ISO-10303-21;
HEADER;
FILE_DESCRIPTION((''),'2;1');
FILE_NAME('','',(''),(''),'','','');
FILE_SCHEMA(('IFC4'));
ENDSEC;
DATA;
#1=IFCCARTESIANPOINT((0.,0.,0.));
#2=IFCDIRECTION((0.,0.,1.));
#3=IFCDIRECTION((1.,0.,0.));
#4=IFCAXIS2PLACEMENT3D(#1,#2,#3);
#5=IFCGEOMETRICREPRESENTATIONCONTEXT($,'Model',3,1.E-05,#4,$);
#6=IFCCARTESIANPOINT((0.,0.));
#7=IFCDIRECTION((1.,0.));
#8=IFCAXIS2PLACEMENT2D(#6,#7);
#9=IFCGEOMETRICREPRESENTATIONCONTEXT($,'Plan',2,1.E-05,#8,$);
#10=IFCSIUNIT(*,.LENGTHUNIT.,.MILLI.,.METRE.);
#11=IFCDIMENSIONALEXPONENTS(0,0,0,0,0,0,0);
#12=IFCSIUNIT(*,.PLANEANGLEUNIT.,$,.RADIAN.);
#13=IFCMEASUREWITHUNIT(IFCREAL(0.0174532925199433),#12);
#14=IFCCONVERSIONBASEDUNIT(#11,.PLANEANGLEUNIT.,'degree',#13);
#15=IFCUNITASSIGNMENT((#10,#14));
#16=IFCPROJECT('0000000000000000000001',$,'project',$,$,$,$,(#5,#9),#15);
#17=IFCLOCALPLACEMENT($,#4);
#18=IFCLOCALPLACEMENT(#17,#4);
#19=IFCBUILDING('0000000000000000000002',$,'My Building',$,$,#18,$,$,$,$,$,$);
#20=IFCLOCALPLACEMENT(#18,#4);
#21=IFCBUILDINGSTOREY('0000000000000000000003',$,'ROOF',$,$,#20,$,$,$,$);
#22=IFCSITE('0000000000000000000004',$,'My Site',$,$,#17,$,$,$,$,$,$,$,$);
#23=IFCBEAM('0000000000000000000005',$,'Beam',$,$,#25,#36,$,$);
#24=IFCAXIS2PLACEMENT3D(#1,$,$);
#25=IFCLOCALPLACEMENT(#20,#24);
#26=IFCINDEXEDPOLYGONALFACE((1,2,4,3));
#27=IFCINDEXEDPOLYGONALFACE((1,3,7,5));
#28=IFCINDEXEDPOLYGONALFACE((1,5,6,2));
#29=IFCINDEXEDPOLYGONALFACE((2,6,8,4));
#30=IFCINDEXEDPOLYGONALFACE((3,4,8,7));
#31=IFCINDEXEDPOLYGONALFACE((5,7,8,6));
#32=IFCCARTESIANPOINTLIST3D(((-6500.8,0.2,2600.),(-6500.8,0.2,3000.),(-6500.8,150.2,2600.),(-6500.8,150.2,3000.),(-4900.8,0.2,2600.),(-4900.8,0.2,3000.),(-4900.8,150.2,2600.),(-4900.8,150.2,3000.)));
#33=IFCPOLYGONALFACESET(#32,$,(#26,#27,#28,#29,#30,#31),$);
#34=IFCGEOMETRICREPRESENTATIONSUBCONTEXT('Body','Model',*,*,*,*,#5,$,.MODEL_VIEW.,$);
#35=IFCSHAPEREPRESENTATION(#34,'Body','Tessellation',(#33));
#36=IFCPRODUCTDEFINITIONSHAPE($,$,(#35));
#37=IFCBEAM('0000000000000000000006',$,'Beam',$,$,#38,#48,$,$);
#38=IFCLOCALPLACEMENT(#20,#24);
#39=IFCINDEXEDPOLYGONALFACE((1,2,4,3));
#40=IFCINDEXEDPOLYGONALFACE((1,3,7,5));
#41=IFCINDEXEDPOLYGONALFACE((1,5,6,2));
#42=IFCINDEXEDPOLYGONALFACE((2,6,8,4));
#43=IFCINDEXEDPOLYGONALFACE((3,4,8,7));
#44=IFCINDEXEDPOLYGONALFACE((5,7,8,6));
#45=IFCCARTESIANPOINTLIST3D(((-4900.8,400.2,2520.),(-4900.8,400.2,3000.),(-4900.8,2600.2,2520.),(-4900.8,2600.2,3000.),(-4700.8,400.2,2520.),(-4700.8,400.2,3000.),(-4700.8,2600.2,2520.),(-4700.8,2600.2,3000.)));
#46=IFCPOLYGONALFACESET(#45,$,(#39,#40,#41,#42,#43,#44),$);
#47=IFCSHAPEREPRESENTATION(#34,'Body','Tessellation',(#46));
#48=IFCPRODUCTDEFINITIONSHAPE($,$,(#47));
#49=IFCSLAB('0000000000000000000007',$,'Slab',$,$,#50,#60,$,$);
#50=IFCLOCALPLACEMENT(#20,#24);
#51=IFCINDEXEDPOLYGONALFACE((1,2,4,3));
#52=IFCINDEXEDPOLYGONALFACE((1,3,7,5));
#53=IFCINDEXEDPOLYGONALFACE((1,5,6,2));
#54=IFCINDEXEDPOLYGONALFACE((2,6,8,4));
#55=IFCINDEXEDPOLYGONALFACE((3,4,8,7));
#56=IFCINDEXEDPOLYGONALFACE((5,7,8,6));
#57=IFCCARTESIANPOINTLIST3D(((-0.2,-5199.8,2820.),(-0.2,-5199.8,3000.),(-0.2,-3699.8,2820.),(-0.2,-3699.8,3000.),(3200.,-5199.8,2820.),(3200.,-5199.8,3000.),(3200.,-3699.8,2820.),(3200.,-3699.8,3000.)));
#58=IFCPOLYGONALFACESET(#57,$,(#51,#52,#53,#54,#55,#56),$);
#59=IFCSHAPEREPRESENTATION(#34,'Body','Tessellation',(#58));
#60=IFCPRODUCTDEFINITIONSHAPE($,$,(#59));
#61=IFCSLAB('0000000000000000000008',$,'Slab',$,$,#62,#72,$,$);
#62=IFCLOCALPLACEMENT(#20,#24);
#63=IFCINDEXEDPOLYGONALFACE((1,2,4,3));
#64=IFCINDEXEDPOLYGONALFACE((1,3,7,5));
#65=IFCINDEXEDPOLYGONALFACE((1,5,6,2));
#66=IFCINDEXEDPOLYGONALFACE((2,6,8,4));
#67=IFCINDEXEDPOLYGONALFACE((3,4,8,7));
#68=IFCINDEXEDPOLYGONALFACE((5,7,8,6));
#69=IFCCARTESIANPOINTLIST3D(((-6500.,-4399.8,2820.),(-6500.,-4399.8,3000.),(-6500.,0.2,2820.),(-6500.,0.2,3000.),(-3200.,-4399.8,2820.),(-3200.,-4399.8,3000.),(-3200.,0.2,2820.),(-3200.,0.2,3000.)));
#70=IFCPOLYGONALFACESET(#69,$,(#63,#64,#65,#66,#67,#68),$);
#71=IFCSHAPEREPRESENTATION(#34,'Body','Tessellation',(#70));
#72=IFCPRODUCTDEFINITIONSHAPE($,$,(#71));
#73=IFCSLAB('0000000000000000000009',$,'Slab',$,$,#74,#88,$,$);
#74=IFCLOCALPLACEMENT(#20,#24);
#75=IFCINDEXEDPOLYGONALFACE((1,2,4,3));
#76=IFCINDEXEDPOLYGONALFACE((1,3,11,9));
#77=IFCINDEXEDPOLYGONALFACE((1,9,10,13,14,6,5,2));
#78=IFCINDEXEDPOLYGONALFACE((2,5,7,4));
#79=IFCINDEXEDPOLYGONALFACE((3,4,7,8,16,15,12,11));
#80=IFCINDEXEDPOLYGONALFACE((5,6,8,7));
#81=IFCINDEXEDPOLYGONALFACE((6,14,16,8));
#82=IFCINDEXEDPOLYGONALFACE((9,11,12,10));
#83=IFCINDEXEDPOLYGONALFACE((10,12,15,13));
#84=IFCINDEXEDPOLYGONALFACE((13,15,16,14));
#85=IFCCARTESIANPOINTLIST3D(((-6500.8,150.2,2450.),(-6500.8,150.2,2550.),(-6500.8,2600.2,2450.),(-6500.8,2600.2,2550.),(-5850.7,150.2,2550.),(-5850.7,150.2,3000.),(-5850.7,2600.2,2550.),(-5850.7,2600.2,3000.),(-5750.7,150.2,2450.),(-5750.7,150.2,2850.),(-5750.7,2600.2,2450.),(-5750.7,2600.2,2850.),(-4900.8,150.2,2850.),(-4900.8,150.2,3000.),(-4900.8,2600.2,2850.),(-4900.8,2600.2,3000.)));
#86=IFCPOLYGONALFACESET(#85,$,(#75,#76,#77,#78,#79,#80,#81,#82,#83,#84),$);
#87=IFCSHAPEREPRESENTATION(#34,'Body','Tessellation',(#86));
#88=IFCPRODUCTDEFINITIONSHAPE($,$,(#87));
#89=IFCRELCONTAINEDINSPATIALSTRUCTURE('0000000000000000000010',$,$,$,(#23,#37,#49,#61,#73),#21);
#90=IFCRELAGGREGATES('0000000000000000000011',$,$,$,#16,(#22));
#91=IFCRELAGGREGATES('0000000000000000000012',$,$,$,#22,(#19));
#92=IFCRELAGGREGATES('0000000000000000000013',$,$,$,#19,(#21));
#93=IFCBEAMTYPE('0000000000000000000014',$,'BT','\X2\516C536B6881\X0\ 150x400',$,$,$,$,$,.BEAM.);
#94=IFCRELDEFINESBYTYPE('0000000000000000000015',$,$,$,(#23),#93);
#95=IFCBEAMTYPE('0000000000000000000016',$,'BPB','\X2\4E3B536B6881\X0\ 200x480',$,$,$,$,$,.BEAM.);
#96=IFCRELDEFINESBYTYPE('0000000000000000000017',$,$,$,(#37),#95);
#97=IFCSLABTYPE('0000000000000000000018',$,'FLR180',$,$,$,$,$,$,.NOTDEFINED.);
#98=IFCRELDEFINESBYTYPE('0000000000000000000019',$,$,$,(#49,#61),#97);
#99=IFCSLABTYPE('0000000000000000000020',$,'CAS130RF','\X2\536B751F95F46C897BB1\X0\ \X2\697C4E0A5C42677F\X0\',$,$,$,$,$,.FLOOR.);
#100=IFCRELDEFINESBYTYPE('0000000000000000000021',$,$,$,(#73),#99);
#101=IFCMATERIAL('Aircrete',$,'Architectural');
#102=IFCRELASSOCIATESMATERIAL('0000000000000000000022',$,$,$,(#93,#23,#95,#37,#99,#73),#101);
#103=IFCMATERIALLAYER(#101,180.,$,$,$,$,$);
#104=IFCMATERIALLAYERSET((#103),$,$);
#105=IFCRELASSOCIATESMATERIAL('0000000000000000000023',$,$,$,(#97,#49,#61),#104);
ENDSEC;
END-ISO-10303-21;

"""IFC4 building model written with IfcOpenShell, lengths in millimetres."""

from ifc_helpers import new_model, entity, si_unit, converted_unit, frame, origin_with_axes, origin_2d_with_axis, place, context, subcontext, project, spatial, indexed_curve, rectangle, outline, extrude, material, layer, layer_set, layer_usage, material_profile, profile_set, profile_usage, type_object, element, save


model = new_model("IFC4")

# Units and contexts
model_context = context("Model", 3, precision=1e-05, world=origin_with_axes())
plan_context = context("Plan", 2, precision=1e-05, world=origin_2d_with_axis())
body_context = subcontext(model_context, "Body", "Model", "MODEL_VIEW")
ifc_project = project(units=[si_unit("LENGTHUNIT", "METRE", prefix="MILLI"), converted_unit("PLANEANGLEUNIT", "degree", entity("IfcReal", 0.0174532925199433), si_unit("PLANEANGLEUNIT", "RADIAN"), dimensions=[0, 0, 0, 0, 0, 0, 0])], contexts=[model_context, plan_context])

# Site, building, storey
site_placement = place(None, origin_with_axes())
site = spatial("IfcSite", under=ifc_project, at=site_placement, Name="My Site")
building_placement = place(site_placement, origin_with_axes())
building = spatial("IfcBuilding", under=site, at=building_placement, Name="My Building")
storey_placement = place(building_placement, origin_with_axes())
storey = spatial("IfcBuildingStorey", under=building, at=storey_placement, Name="ROOF")

# Beams
ifc_material = material(Name="Aircrete", Category="Architectural")
ifc_material_profile_1 = material_profile(ifc_material, rectangle(XDim=150.0, YDim=400.0))
ifc_profile_set_1 = profile_set([ifc_material_profile_1])
ifc_profile_usage_1 = profile_usage(ifc_profile_set_1, cardinal=9)
beam_type_1 = type_object("IfcBeamType", Name="BT", Description="公卫梁 150x400", PredefinedType="BEAM", material=ifc_profile_set_1)
beam_1_placement = place(storey_placement, frame((-4900.8, 150.2, 3000.0), z_axis=(-1.0, 0.0, 0.0), x_axis=(0.0, -1.0, 0.0)))
element("IfcBeam", 1, at=beam_1_placement, inside=storey, type_object=beam_type_1, material=ifc_profile_usage_1, Name="Beam", context=body_context, shape_type="SweptSolid", body=[
    extrude(rectangle(XDim=150.0, YDim=400.0), frame((75.0, -200.0, 0.0), z_axis=(0.0, 0.0, 1.0), x_axis=(1.0, 0.0, 0.0)), (0.0, 0.0, 1.0), 1600.0),
])
ifc_material_profile_2 = material_profile(ifc_material, rectangle(XDim=200.0, YDim=480.0))
ifc_profile_set_2 = profile_set([ifc_material_profile_2])
ifc_profile_usage_2 = profile_usage(ifc_profile_set_2, cardinal=9)
beam_type_2 = type_object("IfcBeamType", Name="BPB", Description="主卫梁 200x480", PredefinedType="BEAM", material=ifc_profile_set_2)
beam_2_placement = place(storey_placement, frame((-4900.8, 2600.2, 3000.0), z_axis=(0.0, -1.0, 0.0), x_axis=(1.0, 0.0, 0.0)))
element("IfcBeam", 2, at=beam_2_placement, inside=storey, type_object=beam_type_2, material=ifc_profile_usage_2, Name="Beam", context=body_context, shape_type="SweptSolid", body=[
    extrude(rectangle(XDim=200.0, YDim=480.0), frame((100.0, -240.0, 0.0), z_axis=(0.0, 0.0, 1.0), x_axis=(1.0, 0.0, 0.0)), (0.0, 0.0, 1.0), 2200.0),
])

# Slabs
ifc_layer_1 = layer(ifc_material, 180.0)
ifc_layer_set_1 = layer_set([ifc_layer_1])
ifc_layer_usage_1 = layer_usage(ifc_layer_set_1, "AXIS3", "POSITIVE", 0.0)
slab_type_1 = type_object("IfcSlabType", Name="FLR180", PredefinedType="NOTDEFINED", material=ifc_layer_set_1)
slab_1_placement = place(storey_placement, frame((0.0, -3699.8, 3000.0), z_axis=(0.0, 0.0, -1.0), x_axis=(1.0, 0.0, 0.0)))
element("IfcSlab", 3, at=slab_1_placement, inside=storey, type_object=slab_type_1, material=ifc_layer_usage_1, Name="Slab", context=body_context, shape_type="SweptSolid", body=[
    extrude(outline(indexed_curve([(-0.2, 1500.0), (3200.0, 1500.0), (3200.0, 0.0), (-0.2, 0.0), (-0.2, 1500.0)])), None, (0.0, 0.0, 1.0), 180.0),
])
ifc_layer_usage_2 = layer_usage(ifc_layer_set_1, "AXIS3", "POSITIVE", 0.0)
slab_2_placement = place(storey_placement, frame((-6500.0, -4399.8, 2820.0), z_axis=(0.0, 0.0, 1.0), x_axis=(1.0, 0.0, 0.0)))
element("IfcSlab", 4, at=slab_2_placement, inside=storey, type_object=slab_type_1, material=ifc_layer_usage_2, Name="Slab", context=body_context, shape_type="SweptSolid", body=[
    extrude(outline(indexed_curve([(0.0, 4400.0), (3300.0, 4400.0), (3300.0, 0.0), (0.0, 0.0), (0.0, 4400.0)])), None, (0.0, 0.0, 1.0), 180.0),
])

# Shared definitions
ifc_material_profile_3 = material_profile(ifc_material, outline(indexed_curve([(950.0, -450.0), (1600.0, -450.0), (1600.0, -550.0), (850.0, -550.0), (850.0, -150.0), (0.0, -150.0), (0.0, 0.0), (950.0, 0.0), (950.0, -450.0)])))
ifc_profile_set_3 = profile_set([ifc_material_profile_3])
slab_type_2 = type_object("IfcSlabType", Name="CAS130RF", Description="卫生间沉箱 楼上层板", PredefinedType="FLOOR", material=ifc_profile_set_3)

# Slab
ifc_profile_usage_3 = profile_usage(ifc_profile_set_3)
slab_3_placement = place(storey_placement, frame((-4900.8, 150.2, 3000.0), z_axis=(0.0, 1.0, 0.0), x_axis=(-1.0, 0.0, 0.0)))
element("IfcSlab", 5, at=slab_3_placement, inside=storey, type_object=slab_type_2, material=ifc_profile_usage_3, Name="Slab", context=body_context, shape_type="SweptSolid", body=[
    extrude(outline(indexed_curve([(950.0, -450.0), (1600.0, -450.0), (1600.0, -550.0), (850.0, -550.0), (850.0, -150.0), (0.0, -150.0), (0.0, 0.0), (950.0, 0.0), (950.0, -450.0)])), origin_with_axes(), (0.0, 0.0, 1.0), 2450.0),
])

save(model, "model.ifc")
